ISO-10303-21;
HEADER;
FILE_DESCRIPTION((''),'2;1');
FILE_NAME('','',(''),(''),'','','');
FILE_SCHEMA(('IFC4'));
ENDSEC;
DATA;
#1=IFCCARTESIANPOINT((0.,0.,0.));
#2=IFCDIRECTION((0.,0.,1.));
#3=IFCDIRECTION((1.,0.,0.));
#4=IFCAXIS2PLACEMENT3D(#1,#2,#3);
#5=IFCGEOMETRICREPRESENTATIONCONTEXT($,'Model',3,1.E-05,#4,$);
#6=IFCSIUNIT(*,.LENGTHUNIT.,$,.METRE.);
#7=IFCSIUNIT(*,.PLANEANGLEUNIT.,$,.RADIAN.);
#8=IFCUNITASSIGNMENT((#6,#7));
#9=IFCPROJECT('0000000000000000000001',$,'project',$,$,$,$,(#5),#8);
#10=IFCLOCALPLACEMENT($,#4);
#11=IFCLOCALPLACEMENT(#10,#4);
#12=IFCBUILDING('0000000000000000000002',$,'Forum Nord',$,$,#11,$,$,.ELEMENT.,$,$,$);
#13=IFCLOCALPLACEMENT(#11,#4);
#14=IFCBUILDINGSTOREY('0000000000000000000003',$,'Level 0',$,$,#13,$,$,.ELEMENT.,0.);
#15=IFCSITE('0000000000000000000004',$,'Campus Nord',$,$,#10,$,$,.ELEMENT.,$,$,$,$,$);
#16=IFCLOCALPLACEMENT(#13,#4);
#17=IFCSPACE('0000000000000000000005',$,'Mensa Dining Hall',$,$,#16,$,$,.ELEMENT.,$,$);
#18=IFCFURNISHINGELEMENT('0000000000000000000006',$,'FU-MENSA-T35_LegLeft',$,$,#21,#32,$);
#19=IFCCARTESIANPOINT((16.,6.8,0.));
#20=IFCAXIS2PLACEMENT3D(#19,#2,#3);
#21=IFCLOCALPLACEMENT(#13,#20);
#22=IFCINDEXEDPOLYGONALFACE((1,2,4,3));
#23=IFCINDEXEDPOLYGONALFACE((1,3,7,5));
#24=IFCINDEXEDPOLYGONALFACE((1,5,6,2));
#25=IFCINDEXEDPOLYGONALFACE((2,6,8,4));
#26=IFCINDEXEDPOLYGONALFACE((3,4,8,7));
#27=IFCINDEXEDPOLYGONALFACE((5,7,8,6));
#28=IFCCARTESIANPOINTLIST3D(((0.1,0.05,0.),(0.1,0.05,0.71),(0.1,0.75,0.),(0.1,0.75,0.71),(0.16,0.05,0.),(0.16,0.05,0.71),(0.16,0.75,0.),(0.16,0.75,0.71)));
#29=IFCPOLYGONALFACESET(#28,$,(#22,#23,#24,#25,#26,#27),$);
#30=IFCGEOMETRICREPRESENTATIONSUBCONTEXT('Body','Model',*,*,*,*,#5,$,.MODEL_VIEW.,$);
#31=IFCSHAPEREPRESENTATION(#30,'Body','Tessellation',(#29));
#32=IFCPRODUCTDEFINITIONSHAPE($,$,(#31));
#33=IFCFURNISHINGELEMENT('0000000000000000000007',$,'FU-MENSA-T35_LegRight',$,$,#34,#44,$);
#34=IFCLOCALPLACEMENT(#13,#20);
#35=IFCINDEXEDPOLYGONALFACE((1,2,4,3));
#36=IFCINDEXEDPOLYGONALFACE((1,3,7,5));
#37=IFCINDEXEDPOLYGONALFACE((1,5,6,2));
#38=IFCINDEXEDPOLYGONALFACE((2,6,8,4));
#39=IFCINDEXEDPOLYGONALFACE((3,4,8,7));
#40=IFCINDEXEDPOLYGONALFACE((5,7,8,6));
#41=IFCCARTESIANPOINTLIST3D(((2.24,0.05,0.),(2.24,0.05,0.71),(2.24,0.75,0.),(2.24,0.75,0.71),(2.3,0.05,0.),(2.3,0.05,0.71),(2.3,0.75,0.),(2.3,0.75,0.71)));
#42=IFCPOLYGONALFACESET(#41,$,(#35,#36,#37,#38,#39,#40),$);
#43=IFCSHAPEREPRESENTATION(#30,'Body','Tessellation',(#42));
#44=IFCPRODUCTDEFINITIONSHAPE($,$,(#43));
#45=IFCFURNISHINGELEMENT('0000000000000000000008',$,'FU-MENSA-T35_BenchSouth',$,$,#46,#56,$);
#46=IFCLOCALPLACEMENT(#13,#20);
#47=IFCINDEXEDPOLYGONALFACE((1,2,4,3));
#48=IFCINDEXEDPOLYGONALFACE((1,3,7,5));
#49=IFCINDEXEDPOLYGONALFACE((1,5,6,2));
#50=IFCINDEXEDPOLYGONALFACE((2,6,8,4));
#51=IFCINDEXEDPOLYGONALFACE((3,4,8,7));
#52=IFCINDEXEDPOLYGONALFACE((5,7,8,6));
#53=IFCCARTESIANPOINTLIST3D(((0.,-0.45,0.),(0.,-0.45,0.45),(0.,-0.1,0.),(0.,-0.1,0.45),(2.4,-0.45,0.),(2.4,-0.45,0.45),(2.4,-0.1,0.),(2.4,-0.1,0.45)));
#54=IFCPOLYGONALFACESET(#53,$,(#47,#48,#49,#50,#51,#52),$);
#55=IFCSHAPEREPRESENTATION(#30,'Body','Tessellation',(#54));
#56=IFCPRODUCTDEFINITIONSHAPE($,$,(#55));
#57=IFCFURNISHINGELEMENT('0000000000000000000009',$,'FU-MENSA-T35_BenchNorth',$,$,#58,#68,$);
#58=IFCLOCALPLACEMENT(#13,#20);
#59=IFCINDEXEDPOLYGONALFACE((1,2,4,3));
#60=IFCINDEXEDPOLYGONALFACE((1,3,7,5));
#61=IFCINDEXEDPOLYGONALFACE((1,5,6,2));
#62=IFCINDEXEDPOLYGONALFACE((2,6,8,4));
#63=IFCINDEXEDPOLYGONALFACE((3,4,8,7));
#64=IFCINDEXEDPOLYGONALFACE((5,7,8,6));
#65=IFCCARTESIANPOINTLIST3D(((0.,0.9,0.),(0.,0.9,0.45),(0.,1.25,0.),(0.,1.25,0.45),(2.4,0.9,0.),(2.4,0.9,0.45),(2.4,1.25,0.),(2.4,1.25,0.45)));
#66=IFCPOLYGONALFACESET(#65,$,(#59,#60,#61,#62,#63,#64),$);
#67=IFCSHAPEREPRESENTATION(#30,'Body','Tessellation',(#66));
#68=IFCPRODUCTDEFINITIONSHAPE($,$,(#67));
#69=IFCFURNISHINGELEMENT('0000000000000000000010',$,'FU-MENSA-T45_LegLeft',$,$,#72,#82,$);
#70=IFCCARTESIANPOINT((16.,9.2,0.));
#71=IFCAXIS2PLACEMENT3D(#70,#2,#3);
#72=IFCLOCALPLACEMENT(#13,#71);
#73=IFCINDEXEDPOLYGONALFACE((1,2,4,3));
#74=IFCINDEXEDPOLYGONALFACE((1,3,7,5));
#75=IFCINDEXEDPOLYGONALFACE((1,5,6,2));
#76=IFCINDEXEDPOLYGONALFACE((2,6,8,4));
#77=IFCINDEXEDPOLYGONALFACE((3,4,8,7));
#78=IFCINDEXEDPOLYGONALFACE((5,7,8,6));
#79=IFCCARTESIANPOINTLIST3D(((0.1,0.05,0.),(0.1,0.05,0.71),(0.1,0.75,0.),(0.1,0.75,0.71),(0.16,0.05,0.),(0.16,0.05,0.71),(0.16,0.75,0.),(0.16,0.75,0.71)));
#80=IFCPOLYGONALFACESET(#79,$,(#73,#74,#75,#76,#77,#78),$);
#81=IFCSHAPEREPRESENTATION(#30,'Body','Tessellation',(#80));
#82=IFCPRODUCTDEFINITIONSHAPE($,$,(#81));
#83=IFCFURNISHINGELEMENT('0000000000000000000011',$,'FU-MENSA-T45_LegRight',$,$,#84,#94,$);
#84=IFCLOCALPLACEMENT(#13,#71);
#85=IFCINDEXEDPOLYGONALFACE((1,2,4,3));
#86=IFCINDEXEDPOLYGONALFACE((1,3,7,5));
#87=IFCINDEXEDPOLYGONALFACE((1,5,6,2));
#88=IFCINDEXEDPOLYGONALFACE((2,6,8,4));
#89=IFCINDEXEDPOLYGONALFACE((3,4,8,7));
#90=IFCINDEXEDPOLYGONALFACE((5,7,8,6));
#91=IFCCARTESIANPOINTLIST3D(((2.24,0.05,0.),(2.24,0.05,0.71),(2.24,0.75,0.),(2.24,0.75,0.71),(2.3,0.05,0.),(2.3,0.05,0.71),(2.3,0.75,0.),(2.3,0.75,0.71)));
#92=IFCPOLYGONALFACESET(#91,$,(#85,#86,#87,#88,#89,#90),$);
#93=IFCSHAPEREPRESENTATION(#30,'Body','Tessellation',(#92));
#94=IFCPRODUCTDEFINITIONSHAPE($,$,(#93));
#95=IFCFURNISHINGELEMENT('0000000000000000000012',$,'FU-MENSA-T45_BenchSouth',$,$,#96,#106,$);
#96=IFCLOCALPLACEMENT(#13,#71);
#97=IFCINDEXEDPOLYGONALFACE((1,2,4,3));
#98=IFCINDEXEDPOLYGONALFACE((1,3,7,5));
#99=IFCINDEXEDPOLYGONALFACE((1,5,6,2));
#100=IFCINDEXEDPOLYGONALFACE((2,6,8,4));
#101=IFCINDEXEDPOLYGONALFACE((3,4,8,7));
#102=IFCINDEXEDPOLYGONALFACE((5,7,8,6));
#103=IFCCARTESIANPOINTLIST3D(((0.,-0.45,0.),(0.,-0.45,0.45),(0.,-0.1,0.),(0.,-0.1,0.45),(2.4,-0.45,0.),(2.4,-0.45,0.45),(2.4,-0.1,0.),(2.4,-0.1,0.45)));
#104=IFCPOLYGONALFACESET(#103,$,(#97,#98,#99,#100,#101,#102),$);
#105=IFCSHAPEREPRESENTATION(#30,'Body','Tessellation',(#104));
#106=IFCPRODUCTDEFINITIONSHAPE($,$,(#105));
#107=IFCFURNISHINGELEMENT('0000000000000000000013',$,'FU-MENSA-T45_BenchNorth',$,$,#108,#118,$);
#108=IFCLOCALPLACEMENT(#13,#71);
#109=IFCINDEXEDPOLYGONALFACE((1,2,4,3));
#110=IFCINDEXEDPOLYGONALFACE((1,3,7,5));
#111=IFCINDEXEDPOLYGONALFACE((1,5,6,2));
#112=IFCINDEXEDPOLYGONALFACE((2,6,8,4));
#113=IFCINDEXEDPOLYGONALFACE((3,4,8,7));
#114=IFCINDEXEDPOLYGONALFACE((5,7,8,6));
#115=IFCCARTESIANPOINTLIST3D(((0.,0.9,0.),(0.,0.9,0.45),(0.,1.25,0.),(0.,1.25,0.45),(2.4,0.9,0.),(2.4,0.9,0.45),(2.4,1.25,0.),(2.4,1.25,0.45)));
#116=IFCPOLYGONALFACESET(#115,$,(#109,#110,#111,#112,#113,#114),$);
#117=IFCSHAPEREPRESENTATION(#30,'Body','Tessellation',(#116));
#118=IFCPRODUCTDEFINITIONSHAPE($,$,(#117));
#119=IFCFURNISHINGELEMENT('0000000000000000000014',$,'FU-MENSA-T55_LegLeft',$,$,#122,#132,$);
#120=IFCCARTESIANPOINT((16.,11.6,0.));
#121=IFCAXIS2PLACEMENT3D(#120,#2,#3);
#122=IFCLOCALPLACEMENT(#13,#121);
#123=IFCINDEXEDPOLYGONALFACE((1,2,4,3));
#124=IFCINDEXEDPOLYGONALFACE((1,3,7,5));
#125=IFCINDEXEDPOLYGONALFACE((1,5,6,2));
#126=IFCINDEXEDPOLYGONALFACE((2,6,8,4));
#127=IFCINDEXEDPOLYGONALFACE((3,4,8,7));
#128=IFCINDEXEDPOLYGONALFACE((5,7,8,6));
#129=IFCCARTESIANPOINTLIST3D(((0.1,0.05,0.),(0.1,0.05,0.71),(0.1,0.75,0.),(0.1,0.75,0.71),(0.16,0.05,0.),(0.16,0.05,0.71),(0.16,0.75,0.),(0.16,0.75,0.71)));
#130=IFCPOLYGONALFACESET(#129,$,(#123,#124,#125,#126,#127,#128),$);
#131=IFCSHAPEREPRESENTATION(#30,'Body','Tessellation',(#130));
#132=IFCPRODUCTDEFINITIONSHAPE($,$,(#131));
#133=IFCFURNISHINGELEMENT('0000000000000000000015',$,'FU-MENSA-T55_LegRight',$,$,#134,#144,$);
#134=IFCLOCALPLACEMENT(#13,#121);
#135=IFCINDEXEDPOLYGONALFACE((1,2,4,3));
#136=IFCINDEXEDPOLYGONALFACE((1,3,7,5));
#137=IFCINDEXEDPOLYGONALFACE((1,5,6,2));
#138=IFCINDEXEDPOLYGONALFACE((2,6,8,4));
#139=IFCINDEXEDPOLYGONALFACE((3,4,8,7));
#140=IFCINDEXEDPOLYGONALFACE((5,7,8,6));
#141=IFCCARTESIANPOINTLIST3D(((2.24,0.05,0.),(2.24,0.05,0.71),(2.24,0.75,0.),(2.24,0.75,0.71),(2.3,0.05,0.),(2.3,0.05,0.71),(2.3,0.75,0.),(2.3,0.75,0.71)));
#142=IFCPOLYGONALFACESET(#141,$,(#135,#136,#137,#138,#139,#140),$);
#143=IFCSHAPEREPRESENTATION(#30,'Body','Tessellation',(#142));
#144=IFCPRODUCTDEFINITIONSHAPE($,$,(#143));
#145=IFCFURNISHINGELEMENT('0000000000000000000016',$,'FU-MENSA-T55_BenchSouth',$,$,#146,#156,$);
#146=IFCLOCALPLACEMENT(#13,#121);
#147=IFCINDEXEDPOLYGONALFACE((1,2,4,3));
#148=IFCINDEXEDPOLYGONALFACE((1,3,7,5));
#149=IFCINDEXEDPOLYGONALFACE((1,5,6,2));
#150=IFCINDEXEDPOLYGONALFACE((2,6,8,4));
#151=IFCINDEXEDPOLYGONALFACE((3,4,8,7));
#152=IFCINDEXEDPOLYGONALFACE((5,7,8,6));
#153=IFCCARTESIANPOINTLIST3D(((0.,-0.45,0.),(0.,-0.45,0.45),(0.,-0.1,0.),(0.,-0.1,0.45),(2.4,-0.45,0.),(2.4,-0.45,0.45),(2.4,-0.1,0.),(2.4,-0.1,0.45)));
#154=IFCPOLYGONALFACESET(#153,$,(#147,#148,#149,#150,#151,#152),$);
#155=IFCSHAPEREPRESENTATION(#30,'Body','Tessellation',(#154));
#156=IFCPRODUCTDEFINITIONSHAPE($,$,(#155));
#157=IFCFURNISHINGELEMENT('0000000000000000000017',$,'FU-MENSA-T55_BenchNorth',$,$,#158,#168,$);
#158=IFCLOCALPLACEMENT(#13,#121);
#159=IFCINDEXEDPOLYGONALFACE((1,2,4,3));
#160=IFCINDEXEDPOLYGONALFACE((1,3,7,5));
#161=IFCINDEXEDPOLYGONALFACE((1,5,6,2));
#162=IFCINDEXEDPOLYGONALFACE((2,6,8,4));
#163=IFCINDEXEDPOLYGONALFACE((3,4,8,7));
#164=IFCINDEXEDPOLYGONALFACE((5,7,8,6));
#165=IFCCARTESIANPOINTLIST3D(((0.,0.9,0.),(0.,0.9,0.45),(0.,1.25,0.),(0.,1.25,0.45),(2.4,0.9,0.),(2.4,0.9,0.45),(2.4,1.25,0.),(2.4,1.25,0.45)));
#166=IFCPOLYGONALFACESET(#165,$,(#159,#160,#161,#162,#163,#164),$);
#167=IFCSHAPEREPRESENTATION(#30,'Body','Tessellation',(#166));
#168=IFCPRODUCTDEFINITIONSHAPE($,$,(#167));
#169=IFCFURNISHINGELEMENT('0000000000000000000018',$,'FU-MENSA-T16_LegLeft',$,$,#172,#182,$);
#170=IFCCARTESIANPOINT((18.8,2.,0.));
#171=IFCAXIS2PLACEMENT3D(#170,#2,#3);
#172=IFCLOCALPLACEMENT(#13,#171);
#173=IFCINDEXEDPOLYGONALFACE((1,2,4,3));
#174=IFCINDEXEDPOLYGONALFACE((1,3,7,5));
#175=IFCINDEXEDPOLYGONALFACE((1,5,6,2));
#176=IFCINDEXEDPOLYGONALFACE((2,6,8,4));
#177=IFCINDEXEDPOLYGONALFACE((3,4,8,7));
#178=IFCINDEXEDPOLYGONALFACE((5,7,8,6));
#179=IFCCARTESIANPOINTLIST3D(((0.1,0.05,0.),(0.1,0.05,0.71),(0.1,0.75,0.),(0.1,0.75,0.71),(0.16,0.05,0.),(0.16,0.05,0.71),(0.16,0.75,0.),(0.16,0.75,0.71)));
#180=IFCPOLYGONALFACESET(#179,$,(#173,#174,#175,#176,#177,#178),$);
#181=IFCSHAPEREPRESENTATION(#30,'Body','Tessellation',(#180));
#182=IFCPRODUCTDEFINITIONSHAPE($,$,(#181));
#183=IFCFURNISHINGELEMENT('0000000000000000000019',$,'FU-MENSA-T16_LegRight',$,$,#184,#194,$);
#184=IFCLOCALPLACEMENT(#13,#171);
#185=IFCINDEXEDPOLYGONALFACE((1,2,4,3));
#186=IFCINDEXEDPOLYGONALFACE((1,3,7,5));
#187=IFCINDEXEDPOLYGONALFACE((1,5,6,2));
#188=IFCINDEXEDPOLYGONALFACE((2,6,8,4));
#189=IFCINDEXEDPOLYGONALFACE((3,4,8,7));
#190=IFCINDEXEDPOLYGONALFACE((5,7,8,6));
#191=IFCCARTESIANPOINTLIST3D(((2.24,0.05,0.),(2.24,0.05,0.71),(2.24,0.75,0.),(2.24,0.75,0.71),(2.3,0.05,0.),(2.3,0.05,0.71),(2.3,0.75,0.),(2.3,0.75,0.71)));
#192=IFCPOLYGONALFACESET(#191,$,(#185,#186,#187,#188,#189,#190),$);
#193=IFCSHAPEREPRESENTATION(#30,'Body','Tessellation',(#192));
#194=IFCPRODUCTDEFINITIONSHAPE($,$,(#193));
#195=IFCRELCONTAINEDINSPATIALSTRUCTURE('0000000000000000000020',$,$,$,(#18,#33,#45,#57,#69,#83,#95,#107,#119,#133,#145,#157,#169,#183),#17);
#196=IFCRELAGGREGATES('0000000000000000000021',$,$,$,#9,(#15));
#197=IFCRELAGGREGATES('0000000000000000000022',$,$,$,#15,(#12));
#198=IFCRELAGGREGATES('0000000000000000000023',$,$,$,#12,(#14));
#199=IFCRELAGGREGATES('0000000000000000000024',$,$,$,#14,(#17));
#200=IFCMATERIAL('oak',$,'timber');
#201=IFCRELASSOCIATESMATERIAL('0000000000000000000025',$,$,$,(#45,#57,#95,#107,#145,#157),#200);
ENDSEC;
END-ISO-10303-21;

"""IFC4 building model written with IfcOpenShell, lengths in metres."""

from ifc_helpers import new_model, si_unit, frame, frame_2d, origin_with_axes, place, context, subcontext, project, spatial, rectangle, extrude, material, element, save


model = new_model("IFC4")

# Units and contexts
model_context = context("Model", 3, precision=1e-05, world=origin_with_axes())
body_context = subcontext(model_context, "Body", "Model", "MODEL_VIEW")
ifc_project = project(units=[si_unit("LENGTHUNIT", "METRE"), si_unit("PLANEANGLEUNIT", "RADIAN")], contexts=[model_context])

# Site, building, storey, space
site_placement = place(None, origin_with_axes())
site = spatial("IfcSite", under=ifc_project, at=site_placement, Name="Campus Nord", CompositionType="ELEMENT")
building_placement = place(site_placement, origin_with_axes())
building = spatial("IfcBuilding", under=site, at=building_placement, Name="Forum Nord", CompositionType="ELEMENT")
storey_placement = place(building_placement, origin_with_axes())
storey = spatial("IfcBuildingStorey", under=building, at=storey_placement, Name="Level 0", CompositionType="ELEMENT", Elevation=0.0)
space_placement = place(storey_placement, origin_with_axes())
space = spatial("IfcSpace", under=storey, at=space_placement, Name="Mensa Dining Hall", CompositionType="ELEMENT")

# Furnishing elements
furnishing_1_placement = place(storey_placement, frame((16.0, 6.8, 0.0), z_axis=(0.0, 0.0, 1.0), x_axis=(1.0, 0.0, 0.0)))
element("IfcFurnishingElement", 1, at=furnishing_1_placement, inside=space, Name="FU-MENSA-T35_LegLeft", context=body_context, shape_type="SweptSolid", body=[
    extrude(rectangle(XDim=0.06, YDim=0.7, at=frame_2d((0.13, 0.4), x_axis=(1.0, 0.0))), origin_with_axes(), (0.0, 0.0, 1.0), 0.71),
])
furnishing_2_placement = place(storey_placement, frame((16.0, 6.8, 0.0), z_axis=(0.0, 0.0, 1.0), x_axis=(1.0, 0.0, 0.0)))
element("IfcFurnishingElement", 2, at=furnishing_2_placement, inside=space, Name="FU-MENSA-T35_LegRight", context=body_context, shape_type="SweptSolid", body=[
    extrude(rectangle(XDim=0.06, YDim=0.7, at=frame_2d((2.27, 0.4), x_axis=(1.0, 0.0))), origin_with_axes(), (0.0, 0.0, 1.0), 0.71),
])
ifc_material_1 = material(Name="oak", Category="timber")
furnishing_3_placement = place(storey_placement, frame((16.0, 6.8, 0.0), z_axis=(0.0, 0.0, 1.0), x_axis=(1.0, 0.0, 0.0)))
element("IfcFurnishingElement", 3, at=furnishing_3_placement, inside=space, material=ifc_material_1, Name="FU-MENSA-T35_BenchSouth", context=body_context, shape_type="SweptSolid", body=[
    extrude(rectangle(XDim=2.4, YDim=0.35, at=frame_2d((1.2, -0.275), x_axis=(1.0, 0.0))), origin_with_axes(), (0.0, 0.0, 1.0), 0.45),
])
furnishing_4_placement = place(storey_placement, frame((16.0, 6.8, 0.0), z_axis=(0.0, 0.0, 1.0), x_axis=(1.0, 0.0, 0.0)))
element("IfcFurnishingElement", 4, at=furnishing_4_placement, inside=space, material=ifc_material_1, Name="FU-MENSA-T35_BenchNorth", context=body_context, shape_type="SweptSolid", body=[
    extrude(rectangle(XDim=2.4, YDim=0.35, at=frame_2d((1.2, 1.075), x_axis=(1.0, 0.0))), origin_with_axes(), (0.0, 0.0, 1.0), 0.45),
])
furnishing_5_placement = place(storey_placement, frame((16.0, 9.2, 0.0), z_axis=(0.0, 0.0, 1.0), x_axis=(1.0, 0.0, 0.0)))
element("IfcFurnishingElement", 5, at=furnishing_5_placement, inside=space, Name="FU-MENSA-T45_LegLeft", context=body_context, shape_type="SweptSolid", body=[
    extrude(rectangle(XDim=0.06, YDim=0.7, at=frame_2d((0.13, 0.4), x_axis=(1.0, 0.0))), origin_with_axes(), (0.0, 0.0, 1.0), 0.71),
])
furnishing_6_placement = place(storey_placement, frame((16.0, 9.2, 0.0), z_axis=(0.0, 0.0, 1.0), x_axis=(1.0, 0.0, 0.0)))
element("IfcFurnishingElement", 6, at=furnishing_6_placement, inside=space, Name="FU-MENSA-T45_LegRight", context=body_context, shape_type="SweptSolid", body=[
    extrude(rectangle(XDim=0.06, YDim=0.7, at=frame_2d((2.27, 0.4), x_axis=(1.0, 0.0))), origin_with_axes(), (0.0, 0.0, 1.0), 0.71),
])
furnishing_7_placement = place(storey_placement, frame((16.0, 9.2, 0.0), z_axis=(0.0, 0.0, 1.0), x_axis=(1.0, 0.0, 0.0)))
element("IfcFurnishingElement", 7, at=furnishing_7_placement, inside=space, material=ifc_material_1, Name="FU-MENSA-T45_BenchSouth", context=body_context, shape_type="SweptSolid", body=[
    extrude(rectangle(XDim=2.4, YDim=0.35, at=frame_2d((1.2, -0.275), x_axis=(1.0, 0.0))), origin_with_axes(), (0.0, 0.0, 1.0), 0.45),
])
furnishing_8_placement = place(storey_placement, frame((16.0, 9.2, 0.0), z_axis=(0.0, 0.0, 1.0), x_axis=(1.0, 0.0, 0.0)))
element("IfcFurnishingElement", 8, at=furnishing_8_placement, inside=space, material=ifc_material_1, Name="FU-MENSA-T45_BenchNorth", context=body_context, shape_type="SweptSolid", body=[
    extrude(rectangle(XDim=2.4, YDim=0.35, at=frame_2d((1.2, 1.075), x_axis=(1.0, 0.0))), origin_with_axes(), (0.0, 0.0, 1.0), 0.45),
])
furnishing_9_placement = place(storey_placement, frame((16.0, 11.6, 0.0), z_axis=(0.0, 0.0, 1.0), x_axis=(1.0, 0.0, 0.0)))
element("IfcFurnishingElement", 9, at=furnishing_9_placement, inside=space, Name="FU-MENSA-T55_LegLeft", context=body_context, shape_type="SweptSolid", body=[
    extrude(rectangle(XDim=0.06, YDim=0.7, at=frame_2d((0.13, 0.4), x_axis=(1.0, 0.0))), origin_with_axes(), (0.0, 0.0, 1.0), 0.71),
])
furnishing_10_placement = place(storey_placement, frame((16.0, 11.6, 0.0), z_axis=(0.0, 0.0, 1.0), x_axis=(1.0, 0.0, 0.0)))
element("IfcFurnishingElement", 10, at=furnishing_10_placement, inside=space, Name="FU-MENSA-T55_LegRight", context=body_context, shape_type="SweptSolid", body=[
    extrude(rectangle(XDim=0.06, YDim=0.7, at=frame_2d((2.27, 0.4), x_axis=(1.0, 0.0))), origin_with_axes(), (0.0, 0.0, 1.0), 0.71),
])
furnishing_11_placement = place(storey_placement, frame((16.0, 11.6, 0.0), z_axis=(0.0, 0.0, 1.0), x_axis=(1.0, 0.0, 0.0)))
element("IfcFurnishingElement", 11, at=furnishing_11_placement, inside=space, material=ifc_material_1, Name="FU-MENSA-T55_BenchSouth", context=body_context, shape_type="SweptSolid", body=[
    extrude(rectangle(XDim=2.4, YDim=0.35, at=frame_2d((1.2, -0.275), x_axis=(1.0, 0.0))), origin_with_axes(), (0.0, 0.0, 1.0), 0.45),
])
furnishing_12_placement = place(storey_placement, frame((16.0, 11.6, 0.0), z_axis=(0.0, 0.0, 1.0), x_axis=(1.0, 0.0, 0.0)))
element("IfcFurnishingElement", 12, at=furnishing_12_placement, inside=space, material=ifc_material_1, Name="FU-MENSA-T55_BenchNorth", context=body_context, shape_type="SweptSolid", body=[
    extrude(rectangle(XDim=2.4, YDim=0.35, at=frame_2d((1.2, 1.075), x_axis=(1.0, 0.0))), origin_with_axes(), (0.0, 0.0, 1.0), 0.45),
])
furnishing_13_placement = place(storey_placement, frame((18.8, 2.0, 0.0), z_axis=(0.0, 0.0, 1.0), x_axis=(1.0, 0.0, 0.0)))
element("IfcFurnishingElement", 13, at=furnishing_13_placement, inside=space, Name="FU-MENSA-T16_LegLeft", context=body_context, shape_type="SweptSolid", body=[
    extrude(rectangle(XDim=0.06, YDim=0.7, at=frame_2d((0.13, 0.4), x_axis=(1.0, 0.0))), origin_with_axes(), (0.0, 0.0, 1.0), 0.71),
])
furnishing_14_placement = place(storey_placement, frame((18.8, 2.0, 0.0), z_axis=(0.0, 0.0, 1.0), x_axis=(1.0, 0.0, 0.0)))
element("IfcFurnishingElement", 14, at=furnishing_14_placement, inside=space, Name="FU-MENSA-T16_LegRight", context=body_context, shape_type="SweptSolid", body=[
    extrude(rectangle(XDim=0.06, YDim=0.7, at=frame_2d((2.27, 0.4), x_axis=(1.0, 0.0))), origin_with_axes(), (0.0, 0.0, 1.0), 0.71),
])

save(model, "model.ifc")
